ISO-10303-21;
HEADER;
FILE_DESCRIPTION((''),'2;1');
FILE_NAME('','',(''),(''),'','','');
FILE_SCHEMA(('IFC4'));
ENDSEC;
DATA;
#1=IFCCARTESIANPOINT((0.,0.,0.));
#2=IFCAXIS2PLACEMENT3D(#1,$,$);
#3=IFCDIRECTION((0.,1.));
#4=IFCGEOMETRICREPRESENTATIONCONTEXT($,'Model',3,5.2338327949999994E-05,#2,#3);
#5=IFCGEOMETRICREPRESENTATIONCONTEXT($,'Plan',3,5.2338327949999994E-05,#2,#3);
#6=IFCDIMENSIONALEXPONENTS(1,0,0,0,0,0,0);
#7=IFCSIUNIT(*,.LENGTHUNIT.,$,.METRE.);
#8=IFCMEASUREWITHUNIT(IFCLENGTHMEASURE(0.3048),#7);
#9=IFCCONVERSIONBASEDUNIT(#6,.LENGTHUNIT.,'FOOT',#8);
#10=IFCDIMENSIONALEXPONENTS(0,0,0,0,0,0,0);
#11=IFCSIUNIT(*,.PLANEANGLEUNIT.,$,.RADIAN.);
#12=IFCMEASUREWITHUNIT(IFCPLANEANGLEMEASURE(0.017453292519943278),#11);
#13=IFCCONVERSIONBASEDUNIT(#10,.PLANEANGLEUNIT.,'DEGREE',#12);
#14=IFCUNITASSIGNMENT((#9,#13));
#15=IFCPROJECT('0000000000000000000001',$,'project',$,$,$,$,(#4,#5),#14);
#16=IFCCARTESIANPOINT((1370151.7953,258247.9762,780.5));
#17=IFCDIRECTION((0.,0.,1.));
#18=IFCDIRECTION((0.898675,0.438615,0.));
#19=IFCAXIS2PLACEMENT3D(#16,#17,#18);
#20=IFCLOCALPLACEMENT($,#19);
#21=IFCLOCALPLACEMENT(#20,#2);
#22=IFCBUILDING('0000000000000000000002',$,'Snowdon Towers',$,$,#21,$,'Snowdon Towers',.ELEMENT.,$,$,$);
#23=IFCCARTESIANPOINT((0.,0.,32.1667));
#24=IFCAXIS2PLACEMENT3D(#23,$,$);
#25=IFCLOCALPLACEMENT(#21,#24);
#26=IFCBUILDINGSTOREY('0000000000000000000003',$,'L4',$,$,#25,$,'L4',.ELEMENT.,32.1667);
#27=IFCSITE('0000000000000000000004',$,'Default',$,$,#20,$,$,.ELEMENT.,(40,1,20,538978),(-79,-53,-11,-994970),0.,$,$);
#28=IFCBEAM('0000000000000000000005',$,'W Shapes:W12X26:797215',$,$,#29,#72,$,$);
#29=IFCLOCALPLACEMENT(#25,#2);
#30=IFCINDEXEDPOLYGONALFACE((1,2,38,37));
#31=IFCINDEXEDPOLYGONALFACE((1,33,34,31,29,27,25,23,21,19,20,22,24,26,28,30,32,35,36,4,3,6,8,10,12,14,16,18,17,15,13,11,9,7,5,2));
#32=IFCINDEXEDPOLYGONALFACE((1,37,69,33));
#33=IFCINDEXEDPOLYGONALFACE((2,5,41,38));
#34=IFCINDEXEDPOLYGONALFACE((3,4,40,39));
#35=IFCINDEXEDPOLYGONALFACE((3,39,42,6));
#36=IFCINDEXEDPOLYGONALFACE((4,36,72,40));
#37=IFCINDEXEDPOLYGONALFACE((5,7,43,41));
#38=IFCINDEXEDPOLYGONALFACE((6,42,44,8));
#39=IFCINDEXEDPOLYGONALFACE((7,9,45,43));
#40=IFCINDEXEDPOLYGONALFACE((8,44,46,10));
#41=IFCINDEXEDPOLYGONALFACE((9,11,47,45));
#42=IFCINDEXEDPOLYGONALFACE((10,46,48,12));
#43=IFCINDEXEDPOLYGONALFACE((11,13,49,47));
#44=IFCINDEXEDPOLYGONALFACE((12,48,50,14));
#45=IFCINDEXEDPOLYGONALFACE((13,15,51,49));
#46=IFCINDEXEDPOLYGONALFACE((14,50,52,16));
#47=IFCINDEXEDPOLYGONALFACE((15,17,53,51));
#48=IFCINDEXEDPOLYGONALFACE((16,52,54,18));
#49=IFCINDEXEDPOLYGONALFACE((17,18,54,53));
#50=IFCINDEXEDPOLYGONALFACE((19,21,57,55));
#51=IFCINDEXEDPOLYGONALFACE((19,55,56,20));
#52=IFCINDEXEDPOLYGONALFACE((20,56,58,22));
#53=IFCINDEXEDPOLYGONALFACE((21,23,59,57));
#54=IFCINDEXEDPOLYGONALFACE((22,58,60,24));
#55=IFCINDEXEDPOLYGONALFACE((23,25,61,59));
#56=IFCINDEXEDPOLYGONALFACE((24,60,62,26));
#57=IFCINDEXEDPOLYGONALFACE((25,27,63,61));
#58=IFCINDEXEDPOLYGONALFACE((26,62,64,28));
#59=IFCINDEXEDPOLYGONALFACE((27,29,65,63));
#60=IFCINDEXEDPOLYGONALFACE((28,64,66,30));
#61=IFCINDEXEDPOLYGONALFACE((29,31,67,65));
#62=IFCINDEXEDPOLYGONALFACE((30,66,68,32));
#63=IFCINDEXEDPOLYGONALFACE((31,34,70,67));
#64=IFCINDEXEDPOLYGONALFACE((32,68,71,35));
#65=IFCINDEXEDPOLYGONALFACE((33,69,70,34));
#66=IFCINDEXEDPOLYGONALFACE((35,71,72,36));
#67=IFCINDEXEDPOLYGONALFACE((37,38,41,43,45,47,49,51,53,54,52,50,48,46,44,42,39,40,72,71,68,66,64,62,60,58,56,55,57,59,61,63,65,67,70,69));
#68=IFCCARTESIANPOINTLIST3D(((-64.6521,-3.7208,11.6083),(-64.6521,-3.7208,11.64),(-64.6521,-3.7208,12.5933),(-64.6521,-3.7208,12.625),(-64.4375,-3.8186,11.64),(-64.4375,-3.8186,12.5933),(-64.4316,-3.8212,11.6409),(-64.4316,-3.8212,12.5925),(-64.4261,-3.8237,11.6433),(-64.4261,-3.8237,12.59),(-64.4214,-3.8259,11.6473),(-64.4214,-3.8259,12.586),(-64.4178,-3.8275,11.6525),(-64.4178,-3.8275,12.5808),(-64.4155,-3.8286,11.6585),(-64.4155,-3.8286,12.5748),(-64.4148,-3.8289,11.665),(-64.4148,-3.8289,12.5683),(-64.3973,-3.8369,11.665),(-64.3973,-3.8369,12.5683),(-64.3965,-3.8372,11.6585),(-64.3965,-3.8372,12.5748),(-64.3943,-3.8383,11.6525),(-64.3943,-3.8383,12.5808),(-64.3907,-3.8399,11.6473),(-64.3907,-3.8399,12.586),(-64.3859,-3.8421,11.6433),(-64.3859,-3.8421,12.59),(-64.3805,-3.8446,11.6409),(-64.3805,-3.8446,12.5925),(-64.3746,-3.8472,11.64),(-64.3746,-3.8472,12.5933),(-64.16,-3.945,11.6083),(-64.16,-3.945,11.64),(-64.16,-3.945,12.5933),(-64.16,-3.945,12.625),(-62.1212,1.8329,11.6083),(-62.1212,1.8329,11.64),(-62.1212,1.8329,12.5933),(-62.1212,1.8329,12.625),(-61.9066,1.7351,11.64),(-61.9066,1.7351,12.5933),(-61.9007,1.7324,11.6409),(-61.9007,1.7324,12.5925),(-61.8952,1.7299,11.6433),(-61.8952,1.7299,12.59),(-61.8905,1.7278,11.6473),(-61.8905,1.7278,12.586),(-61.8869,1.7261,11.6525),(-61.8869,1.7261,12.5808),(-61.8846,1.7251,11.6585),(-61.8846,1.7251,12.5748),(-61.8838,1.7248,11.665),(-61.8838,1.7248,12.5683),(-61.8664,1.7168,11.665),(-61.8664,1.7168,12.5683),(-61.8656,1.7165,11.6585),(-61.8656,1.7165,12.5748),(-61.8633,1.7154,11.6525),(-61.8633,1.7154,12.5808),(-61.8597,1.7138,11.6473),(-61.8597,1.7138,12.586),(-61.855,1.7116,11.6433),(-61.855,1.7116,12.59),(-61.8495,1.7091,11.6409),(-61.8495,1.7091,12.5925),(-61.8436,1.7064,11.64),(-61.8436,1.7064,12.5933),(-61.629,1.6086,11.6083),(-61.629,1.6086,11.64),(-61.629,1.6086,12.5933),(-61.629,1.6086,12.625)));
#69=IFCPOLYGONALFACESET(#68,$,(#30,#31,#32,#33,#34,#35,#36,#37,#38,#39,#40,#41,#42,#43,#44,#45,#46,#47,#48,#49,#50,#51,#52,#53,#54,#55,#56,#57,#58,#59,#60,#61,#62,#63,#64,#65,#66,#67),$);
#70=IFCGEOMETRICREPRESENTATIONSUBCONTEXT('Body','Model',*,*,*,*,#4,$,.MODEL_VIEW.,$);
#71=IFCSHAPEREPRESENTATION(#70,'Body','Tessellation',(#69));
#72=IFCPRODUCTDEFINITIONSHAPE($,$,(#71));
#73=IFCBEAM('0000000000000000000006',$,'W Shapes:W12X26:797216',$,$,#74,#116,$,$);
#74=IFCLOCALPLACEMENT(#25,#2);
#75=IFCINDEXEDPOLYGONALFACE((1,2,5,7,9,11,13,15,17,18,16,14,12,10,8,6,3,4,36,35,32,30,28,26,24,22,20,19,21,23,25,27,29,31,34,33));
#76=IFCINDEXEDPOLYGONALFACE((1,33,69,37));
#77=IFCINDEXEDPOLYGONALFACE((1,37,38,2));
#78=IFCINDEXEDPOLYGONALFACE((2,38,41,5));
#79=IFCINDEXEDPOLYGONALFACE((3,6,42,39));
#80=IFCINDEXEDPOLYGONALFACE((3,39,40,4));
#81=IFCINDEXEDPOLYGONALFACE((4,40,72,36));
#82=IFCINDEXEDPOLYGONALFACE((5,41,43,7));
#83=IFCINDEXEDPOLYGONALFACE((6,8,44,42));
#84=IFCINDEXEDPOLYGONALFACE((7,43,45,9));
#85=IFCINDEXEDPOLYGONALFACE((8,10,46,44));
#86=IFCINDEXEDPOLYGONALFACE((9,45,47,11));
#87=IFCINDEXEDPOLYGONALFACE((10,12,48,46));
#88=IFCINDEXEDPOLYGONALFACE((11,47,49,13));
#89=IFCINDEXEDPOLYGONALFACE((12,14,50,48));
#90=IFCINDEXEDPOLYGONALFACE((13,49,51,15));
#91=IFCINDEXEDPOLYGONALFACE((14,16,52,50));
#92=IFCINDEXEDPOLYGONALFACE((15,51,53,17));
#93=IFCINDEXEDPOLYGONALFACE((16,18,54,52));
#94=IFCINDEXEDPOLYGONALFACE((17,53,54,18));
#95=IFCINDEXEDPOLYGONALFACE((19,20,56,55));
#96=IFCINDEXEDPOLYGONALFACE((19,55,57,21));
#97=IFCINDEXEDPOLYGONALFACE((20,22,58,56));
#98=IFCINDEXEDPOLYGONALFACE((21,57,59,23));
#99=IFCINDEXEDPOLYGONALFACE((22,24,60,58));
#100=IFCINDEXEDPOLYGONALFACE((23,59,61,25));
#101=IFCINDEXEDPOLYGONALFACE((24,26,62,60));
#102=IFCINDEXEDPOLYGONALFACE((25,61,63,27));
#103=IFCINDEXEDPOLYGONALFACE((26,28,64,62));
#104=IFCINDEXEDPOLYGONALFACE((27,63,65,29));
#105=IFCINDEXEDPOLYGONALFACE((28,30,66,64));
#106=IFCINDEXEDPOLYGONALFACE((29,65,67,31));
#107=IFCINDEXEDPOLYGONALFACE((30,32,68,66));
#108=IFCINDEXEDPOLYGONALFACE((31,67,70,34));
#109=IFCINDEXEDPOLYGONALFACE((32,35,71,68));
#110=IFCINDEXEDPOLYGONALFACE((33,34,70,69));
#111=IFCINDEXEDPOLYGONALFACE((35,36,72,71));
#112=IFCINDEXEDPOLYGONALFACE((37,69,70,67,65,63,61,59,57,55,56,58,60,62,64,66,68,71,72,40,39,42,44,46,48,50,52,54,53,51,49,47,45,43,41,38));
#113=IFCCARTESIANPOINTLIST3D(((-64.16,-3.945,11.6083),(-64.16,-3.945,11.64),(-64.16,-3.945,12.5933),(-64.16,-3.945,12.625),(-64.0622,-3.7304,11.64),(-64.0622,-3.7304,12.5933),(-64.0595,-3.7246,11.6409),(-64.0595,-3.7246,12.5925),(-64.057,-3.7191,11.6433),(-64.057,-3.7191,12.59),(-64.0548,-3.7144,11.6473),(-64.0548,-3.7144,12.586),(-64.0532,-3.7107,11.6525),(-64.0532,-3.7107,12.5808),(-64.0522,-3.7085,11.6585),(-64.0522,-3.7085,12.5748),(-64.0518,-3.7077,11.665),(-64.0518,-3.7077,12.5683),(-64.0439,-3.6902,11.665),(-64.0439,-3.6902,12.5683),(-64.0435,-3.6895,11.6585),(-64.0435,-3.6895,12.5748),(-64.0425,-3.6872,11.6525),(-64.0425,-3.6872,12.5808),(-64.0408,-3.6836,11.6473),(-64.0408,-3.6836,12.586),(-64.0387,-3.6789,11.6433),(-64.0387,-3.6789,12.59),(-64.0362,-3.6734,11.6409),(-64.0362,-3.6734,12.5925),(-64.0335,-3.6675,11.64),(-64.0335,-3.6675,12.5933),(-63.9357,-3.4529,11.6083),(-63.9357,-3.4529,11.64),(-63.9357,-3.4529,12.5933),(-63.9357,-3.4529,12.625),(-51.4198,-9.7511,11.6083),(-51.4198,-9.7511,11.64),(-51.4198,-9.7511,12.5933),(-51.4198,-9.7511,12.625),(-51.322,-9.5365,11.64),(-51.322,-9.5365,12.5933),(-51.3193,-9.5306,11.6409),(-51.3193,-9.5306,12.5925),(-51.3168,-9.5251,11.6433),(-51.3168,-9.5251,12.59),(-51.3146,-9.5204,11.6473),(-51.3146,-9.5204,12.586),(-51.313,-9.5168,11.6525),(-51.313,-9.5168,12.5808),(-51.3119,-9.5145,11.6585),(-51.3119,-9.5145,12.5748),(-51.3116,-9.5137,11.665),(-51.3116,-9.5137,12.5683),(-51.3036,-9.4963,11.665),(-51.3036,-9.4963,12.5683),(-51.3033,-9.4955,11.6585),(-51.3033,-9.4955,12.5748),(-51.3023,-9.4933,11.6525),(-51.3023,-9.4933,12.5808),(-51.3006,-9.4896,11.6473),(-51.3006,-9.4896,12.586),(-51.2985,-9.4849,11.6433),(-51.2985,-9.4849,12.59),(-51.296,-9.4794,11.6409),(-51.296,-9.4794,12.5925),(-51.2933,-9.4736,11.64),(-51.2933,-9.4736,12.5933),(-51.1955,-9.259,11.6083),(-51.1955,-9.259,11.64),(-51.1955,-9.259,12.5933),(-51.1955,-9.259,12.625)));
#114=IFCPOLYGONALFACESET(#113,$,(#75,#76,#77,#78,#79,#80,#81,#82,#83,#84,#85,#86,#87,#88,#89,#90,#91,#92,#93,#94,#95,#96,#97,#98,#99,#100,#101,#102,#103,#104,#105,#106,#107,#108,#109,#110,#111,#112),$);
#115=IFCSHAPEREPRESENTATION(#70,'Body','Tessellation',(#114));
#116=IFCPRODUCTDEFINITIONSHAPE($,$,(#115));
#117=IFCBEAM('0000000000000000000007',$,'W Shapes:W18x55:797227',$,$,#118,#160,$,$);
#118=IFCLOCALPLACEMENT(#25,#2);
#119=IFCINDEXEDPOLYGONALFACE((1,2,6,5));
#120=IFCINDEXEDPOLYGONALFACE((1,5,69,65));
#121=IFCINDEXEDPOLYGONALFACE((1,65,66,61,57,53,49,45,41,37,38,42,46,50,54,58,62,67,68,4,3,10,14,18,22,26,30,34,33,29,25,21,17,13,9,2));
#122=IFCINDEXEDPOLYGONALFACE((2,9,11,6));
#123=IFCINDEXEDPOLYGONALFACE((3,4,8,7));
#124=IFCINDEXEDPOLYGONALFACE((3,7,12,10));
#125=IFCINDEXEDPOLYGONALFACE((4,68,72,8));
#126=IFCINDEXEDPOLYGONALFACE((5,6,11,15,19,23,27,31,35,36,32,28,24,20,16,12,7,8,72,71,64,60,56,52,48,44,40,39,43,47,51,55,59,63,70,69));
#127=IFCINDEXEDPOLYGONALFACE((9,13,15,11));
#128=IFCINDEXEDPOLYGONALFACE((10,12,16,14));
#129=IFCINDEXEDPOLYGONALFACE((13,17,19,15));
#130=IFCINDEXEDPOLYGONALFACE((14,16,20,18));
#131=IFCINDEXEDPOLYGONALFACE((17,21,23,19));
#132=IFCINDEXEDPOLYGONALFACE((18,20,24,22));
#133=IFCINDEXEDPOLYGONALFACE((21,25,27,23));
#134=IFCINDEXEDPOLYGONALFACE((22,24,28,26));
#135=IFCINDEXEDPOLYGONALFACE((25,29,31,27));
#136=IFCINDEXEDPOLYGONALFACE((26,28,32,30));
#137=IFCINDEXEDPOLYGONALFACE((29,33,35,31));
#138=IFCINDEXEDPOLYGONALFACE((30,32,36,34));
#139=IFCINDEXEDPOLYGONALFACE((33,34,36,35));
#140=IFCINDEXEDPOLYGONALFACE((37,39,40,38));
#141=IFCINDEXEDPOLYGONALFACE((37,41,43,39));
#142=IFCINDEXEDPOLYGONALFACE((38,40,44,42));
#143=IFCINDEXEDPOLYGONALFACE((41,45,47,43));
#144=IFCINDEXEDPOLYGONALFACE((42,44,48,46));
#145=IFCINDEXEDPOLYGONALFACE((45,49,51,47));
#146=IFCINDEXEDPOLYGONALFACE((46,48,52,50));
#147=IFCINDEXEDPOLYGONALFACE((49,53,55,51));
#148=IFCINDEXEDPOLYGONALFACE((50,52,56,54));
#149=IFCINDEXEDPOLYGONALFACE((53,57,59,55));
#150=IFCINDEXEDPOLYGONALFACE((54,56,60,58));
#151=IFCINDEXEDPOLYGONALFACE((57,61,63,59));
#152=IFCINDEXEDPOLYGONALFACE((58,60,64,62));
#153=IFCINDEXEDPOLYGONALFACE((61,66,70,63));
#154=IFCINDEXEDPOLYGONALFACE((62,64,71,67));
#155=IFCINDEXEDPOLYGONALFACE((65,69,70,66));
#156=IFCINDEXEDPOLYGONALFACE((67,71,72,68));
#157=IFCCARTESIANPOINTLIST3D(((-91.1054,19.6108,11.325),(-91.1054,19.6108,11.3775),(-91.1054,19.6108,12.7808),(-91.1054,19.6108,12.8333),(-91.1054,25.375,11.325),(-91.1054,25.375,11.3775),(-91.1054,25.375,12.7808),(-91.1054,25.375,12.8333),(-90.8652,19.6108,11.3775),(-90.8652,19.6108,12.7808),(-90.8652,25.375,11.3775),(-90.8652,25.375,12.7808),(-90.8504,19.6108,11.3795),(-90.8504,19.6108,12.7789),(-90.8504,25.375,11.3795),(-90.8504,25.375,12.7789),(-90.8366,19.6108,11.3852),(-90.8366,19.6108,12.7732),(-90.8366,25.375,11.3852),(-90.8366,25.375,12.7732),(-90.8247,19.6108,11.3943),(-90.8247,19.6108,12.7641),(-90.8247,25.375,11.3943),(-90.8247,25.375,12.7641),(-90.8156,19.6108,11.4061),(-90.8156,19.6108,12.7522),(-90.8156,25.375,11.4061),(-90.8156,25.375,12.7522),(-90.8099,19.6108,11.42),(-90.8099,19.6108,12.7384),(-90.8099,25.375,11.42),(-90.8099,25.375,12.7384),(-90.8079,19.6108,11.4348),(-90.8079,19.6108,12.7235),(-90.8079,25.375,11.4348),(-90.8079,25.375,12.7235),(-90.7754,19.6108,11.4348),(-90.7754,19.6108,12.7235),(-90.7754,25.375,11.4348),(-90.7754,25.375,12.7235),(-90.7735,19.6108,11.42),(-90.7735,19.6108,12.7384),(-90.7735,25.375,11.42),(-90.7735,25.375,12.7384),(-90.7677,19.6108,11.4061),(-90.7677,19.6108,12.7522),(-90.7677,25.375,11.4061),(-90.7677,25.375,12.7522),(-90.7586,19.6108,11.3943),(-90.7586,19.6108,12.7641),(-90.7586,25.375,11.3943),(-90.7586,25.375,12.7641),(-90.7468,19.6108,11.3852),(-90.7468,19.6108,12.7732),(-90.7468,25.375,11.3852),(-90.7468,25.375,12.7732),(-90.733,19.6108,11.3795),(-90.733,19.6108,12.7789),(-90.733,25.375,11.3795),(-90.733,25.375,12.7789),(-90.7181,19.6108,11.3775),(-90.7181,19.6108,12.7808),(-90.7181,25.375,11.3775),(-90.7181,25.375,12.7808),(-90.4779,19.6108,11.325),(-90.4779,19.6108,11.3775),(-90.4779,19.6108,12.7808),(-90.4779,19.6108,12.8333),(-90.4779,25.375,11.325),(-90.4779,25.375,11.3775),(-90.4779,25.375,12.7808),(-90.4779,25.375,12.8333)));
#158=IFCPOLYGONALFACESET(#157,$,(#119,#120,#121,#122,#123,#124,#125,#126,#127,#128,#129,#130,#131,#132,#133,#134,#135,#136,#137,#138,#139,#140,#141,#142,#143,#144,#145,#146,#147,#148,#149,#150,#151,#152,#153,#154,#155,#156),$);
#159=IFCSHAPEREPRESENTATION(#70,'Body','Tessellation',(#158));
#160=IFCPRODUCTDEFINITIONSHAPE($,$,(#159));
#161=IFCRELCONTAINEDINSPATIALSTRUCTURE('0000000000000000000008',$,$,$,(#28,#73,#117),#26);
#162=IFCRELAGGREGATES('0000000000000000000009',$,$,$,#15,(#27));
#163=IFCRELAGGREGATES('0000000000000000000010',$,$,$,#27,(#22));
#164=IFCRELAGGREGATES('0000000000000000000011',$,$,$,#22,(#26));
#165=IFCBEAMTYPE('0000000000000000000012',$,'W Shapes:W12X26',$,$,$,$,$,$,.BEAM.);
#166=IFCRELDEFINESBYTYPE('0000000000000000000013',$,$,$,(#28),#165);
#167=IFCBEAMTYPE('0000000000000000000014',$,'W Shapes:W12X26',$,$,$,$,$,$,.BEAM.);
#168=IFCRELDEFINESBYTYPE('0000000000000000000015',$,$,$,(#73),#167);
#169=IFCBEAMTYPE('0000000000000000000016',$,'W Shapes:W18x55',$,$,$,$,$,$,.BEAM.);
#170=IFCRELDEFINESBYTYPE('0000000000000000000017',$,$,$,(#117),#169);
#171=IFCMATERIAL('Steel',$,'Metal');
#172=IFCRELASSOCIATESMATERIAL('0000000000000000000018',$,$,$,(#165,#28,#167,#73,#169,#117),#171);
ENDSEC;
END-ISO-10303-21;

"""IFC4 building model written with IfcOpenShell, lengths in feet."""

from ifc_helpers import new_model, entity, si_unit, converted_unit, direction, frame, origin, place, context, subcontext, project, spatial, line, arc, indexed_curve, outline, extrude, source, transform, mapped, material, type_object, type_shapes, element, save


model = new_model("IFC4")

# Units and contexts
model_context = context("Model", 3, precision=5.2338327949999994e-05, world=origin(), true_north=direction((0.0, 1.0)))
plan_context = context("Plan", 3, precision=5.2338327949999994e-05, world=origin(), true_north=direction((0.0, 1.0)))
body_context = subcontext(model_context, "Body", "Model", "MODEL_VIEW")
ifc_project = project(units=[converted_unit("LENGTHUNIT", "FOOT", entity("IfcLengthMeasure", 0.3048), si_unit("LENGTHUNIT", "METRE"), dimensions=[1, 0, 0, 0, 0, 0, 0]), converted_unit("PLANEANGLEUNIT", "DEGREE", entity("IfcPlaneAngleMeasure", 0.017453292519943278), si_unit("PLANEANGLEUNIT", "RADIAN"), dimensions=[0, 0, 0, 0, 0, 0, 0])], contexts=[model_context, plan_context])

# Site, building, storey
site_placement = place(None, frame((1370151.7953, 258247.9762, 780.5), z_axis=(0.0, 0.0, 1.0), x_axis=(0.898675, 0.438615, 0.0)))
site = spatial("IfcSite", under=ifc_project, at=site_placement, Name="Default", CompositionType="ELEMENT", RefLatitude=(40, 1, 20, 538978), RefLongitude=(-79, -53, -11, -994970), RefElevation=0.0)
building_placement = place(site_placement, origin())
building = spatial("IfcBuilding", under=site, at=building_placement, Name="Snowdon Towers", LongName="Snowdon Towers", CompositionType="ELEMENT")
storey_placement = place(building_placement, frame((0.0, 0.0, 32.1667)))
storey = spatial("IfcBuildingStorey", under=building, at=storey_placement, Name="L4", LongName="L4", CompositionType="ELEMENT", Elevation=32.1667)

# Beams
ifc_material = material(Name="Steel", Category="Metal")
beam_type_1 = type_object("IfcBeamType", Name="W Shapes:W12X26", PredefinedType="BEAM", material=ifc_material)
shared_shape_1 = source(origin(), body_context, "Body", "SweptSolid", [
    extrude(outline(indexed_curve([(0.4767, -0.2704), (0.5083, -0.2704), (0.5083, 0.2704), (0.4767, 0.2704), (0.4767, 0.0346), (0.4693, 0.0169), (0.4517, 0.0096), (-0.4517, 0.0096), (-0.4693, 0.0169), (-0.4767, 0.0346), (-0.4767, 0.2704), (-0.5083, 0.2704), (-0.5083, -0.2704), (-0.4767, -0.2704), (-0.4767, -0.0346), (-0.4693, -0.0169), (-0.4517, -0.0096), (0.4517, -0.0096), (0.4693, -0.0169), (0.4767, -0.0346)], segments=[line(1, 2, 3, 4, 5), arc(5, 6, 7), line(7, 8), arc(8, 9, 10), line(10, 11, 12, 13, 14, 15), arc(15, 16, 17), line(17, 18), arc(18, 19, 20), line(20, 1)], self_intersect=False)), frame((-64.406, -3.8329, 44.2833), z_axis=(0.414693, 0.909961, 0.0), x_axis=(0.0, 0.0, 1.0)), (0.0, 0.0, 1.0), 6.1032),
])
type_shapes(beam_type_1, [shared_shape_1])
beam_1_placement = place(storey_placement, frame((0.0, 0.0, -32.1667)))
element("IfcBeam", 1, at=beam_1_placement, inside=storey, type_object=beam_type_1, material=ifc_material, Name="W Shapes:W12X26:797215", context=body_context, shape_type="MappedRepresentation", body=[
    mapped(shared_shape_1, transform((0.0, 0.0, 0.0), scale=1.0)),
])
beam_type_2 = type_object("IfcBeamType", Name="W Shapes:W12X26", PredefinedType="BEAM", material=ifc_material)
shared_shape_2 = source(origin(), body_context, "Body", "SweptSolid", [
    extrude(outline(indexed_curve([(-0.5083, -0.2704), (-0.4767, -0.2704), (-0.4767, -0.0346), (-0.4693, -0.0169), (-0.4517, -0.0096), (0.4517, -0.0096), (0.4693, -0.0169), (0.4767, -0.0346), (0.4767, -0.2704), (0.5083, -0.2704), (0.5083, 0.2704), (0.4767, 0.2704), (0.4767, 0.0346), (0.4693, 0.0169), (0.4517, 0.0096), (-0.4517, 0.0096), (-0.4693, 0.0169), (-0.4767, 0.0346), (-0.4767, 0.2704), (-0.5083, 0.2704)], segments=[line(1, 2, 3), arc(3, 4, 5), line(5, 6), arc(6, 7, 8), line(8, 9, 10, 11, 12, 13), arc(13, 14, 15), line(15, 16), arc(16, 17, 18), line(18, 19, 20, 1)], self_intersect=False)), frame((-64.0478, -3.699, 44.2833), z_axis=(0.909961, -0.414693, 0.0), x_axis=(0.0, 0.0, -1.0)), (0.0, 0.0, 1.0), 14.0008),
])
type_shapes(beam_type_2, [shared_shape_2])
beam_2_placement = place(storey_placement, frame((0.0, 0.0, -32.1667)))
element("IfcBeam", 2, at=beam_2_placement, inside=storey, type_object=beam_type_2, material=ifc_material, Name="W Shapes:W12X26:797216", context=body_context, shape_type="MappedRepresentation", body=[
    mapped(shared_shape_2, transform((0.0, 0.0, 0.0), scale=1.0)),
])
beam_type_3 = type_object("IfcBeamType", Name="W Shapes:W18x55", PredefinedType="BEAM", material=ifc_material)
shared_shape_3 = source(origin(), body_context, "Body", "SweptSolid", [
    extrude(outline(indexed_curve([(-0.3137, -0.7542), (0.3137, -0.7542), (0.3137, -0.7017), (0.0735, -0.7017), (0.033, -0.6849), (0.0162, -0.6444), (0.0162, 0.6444), (0.033, 0.6849), (0.0735, 0.7017), (0.3137, 0.7017), (0.3137, 0.7542), (-0.3137, 0.7542), (-0.3137, 0.7017), (-0.0735, 0.7017), (-0.033, 0.6849), (-0.0162, 0.6444), (-0.0162, -0.6444), (-0.033, -0.6849), (-0.0735, -0.7017), (-0.3137, -0.7017)], segments=[line(1, 2, 3, 4), arc(4, 5, 6), line(6, 7), arc(7, 8, 9), line(9, 10, 11, 12, 13, 14), arc(14, 15, 16), line(16, 17), arc(17, 18, 19), line(19, 20, 1)], self_intersect=False)), frame((-90.7917, 19.6108, 44.2458), z_axis=(0.0, 1.0, 0.0), x_axis=(-1.0, 0.0, 0.0)), (0.0, 0.0, 1.0), 5.7642),
])
type_shapes(beam_type_3, [shared_shape_3])
beam_3_placement = place(storey_placement, frame((0.0, 0.0, -32.1667)))
element("IfcBeam", 3, at=beam_3_placement, inside=storey, type_object=beam_type_3, material=ifc_material, Name="W Shapes:W18x55:797227", context=body_context, shape_type="MappedRepresentation", body=[
    mapped(shared_shape_3, transform((0.0, 0.0, 0.0), scale=1.0)),
])

save(model, "model.ifc")
